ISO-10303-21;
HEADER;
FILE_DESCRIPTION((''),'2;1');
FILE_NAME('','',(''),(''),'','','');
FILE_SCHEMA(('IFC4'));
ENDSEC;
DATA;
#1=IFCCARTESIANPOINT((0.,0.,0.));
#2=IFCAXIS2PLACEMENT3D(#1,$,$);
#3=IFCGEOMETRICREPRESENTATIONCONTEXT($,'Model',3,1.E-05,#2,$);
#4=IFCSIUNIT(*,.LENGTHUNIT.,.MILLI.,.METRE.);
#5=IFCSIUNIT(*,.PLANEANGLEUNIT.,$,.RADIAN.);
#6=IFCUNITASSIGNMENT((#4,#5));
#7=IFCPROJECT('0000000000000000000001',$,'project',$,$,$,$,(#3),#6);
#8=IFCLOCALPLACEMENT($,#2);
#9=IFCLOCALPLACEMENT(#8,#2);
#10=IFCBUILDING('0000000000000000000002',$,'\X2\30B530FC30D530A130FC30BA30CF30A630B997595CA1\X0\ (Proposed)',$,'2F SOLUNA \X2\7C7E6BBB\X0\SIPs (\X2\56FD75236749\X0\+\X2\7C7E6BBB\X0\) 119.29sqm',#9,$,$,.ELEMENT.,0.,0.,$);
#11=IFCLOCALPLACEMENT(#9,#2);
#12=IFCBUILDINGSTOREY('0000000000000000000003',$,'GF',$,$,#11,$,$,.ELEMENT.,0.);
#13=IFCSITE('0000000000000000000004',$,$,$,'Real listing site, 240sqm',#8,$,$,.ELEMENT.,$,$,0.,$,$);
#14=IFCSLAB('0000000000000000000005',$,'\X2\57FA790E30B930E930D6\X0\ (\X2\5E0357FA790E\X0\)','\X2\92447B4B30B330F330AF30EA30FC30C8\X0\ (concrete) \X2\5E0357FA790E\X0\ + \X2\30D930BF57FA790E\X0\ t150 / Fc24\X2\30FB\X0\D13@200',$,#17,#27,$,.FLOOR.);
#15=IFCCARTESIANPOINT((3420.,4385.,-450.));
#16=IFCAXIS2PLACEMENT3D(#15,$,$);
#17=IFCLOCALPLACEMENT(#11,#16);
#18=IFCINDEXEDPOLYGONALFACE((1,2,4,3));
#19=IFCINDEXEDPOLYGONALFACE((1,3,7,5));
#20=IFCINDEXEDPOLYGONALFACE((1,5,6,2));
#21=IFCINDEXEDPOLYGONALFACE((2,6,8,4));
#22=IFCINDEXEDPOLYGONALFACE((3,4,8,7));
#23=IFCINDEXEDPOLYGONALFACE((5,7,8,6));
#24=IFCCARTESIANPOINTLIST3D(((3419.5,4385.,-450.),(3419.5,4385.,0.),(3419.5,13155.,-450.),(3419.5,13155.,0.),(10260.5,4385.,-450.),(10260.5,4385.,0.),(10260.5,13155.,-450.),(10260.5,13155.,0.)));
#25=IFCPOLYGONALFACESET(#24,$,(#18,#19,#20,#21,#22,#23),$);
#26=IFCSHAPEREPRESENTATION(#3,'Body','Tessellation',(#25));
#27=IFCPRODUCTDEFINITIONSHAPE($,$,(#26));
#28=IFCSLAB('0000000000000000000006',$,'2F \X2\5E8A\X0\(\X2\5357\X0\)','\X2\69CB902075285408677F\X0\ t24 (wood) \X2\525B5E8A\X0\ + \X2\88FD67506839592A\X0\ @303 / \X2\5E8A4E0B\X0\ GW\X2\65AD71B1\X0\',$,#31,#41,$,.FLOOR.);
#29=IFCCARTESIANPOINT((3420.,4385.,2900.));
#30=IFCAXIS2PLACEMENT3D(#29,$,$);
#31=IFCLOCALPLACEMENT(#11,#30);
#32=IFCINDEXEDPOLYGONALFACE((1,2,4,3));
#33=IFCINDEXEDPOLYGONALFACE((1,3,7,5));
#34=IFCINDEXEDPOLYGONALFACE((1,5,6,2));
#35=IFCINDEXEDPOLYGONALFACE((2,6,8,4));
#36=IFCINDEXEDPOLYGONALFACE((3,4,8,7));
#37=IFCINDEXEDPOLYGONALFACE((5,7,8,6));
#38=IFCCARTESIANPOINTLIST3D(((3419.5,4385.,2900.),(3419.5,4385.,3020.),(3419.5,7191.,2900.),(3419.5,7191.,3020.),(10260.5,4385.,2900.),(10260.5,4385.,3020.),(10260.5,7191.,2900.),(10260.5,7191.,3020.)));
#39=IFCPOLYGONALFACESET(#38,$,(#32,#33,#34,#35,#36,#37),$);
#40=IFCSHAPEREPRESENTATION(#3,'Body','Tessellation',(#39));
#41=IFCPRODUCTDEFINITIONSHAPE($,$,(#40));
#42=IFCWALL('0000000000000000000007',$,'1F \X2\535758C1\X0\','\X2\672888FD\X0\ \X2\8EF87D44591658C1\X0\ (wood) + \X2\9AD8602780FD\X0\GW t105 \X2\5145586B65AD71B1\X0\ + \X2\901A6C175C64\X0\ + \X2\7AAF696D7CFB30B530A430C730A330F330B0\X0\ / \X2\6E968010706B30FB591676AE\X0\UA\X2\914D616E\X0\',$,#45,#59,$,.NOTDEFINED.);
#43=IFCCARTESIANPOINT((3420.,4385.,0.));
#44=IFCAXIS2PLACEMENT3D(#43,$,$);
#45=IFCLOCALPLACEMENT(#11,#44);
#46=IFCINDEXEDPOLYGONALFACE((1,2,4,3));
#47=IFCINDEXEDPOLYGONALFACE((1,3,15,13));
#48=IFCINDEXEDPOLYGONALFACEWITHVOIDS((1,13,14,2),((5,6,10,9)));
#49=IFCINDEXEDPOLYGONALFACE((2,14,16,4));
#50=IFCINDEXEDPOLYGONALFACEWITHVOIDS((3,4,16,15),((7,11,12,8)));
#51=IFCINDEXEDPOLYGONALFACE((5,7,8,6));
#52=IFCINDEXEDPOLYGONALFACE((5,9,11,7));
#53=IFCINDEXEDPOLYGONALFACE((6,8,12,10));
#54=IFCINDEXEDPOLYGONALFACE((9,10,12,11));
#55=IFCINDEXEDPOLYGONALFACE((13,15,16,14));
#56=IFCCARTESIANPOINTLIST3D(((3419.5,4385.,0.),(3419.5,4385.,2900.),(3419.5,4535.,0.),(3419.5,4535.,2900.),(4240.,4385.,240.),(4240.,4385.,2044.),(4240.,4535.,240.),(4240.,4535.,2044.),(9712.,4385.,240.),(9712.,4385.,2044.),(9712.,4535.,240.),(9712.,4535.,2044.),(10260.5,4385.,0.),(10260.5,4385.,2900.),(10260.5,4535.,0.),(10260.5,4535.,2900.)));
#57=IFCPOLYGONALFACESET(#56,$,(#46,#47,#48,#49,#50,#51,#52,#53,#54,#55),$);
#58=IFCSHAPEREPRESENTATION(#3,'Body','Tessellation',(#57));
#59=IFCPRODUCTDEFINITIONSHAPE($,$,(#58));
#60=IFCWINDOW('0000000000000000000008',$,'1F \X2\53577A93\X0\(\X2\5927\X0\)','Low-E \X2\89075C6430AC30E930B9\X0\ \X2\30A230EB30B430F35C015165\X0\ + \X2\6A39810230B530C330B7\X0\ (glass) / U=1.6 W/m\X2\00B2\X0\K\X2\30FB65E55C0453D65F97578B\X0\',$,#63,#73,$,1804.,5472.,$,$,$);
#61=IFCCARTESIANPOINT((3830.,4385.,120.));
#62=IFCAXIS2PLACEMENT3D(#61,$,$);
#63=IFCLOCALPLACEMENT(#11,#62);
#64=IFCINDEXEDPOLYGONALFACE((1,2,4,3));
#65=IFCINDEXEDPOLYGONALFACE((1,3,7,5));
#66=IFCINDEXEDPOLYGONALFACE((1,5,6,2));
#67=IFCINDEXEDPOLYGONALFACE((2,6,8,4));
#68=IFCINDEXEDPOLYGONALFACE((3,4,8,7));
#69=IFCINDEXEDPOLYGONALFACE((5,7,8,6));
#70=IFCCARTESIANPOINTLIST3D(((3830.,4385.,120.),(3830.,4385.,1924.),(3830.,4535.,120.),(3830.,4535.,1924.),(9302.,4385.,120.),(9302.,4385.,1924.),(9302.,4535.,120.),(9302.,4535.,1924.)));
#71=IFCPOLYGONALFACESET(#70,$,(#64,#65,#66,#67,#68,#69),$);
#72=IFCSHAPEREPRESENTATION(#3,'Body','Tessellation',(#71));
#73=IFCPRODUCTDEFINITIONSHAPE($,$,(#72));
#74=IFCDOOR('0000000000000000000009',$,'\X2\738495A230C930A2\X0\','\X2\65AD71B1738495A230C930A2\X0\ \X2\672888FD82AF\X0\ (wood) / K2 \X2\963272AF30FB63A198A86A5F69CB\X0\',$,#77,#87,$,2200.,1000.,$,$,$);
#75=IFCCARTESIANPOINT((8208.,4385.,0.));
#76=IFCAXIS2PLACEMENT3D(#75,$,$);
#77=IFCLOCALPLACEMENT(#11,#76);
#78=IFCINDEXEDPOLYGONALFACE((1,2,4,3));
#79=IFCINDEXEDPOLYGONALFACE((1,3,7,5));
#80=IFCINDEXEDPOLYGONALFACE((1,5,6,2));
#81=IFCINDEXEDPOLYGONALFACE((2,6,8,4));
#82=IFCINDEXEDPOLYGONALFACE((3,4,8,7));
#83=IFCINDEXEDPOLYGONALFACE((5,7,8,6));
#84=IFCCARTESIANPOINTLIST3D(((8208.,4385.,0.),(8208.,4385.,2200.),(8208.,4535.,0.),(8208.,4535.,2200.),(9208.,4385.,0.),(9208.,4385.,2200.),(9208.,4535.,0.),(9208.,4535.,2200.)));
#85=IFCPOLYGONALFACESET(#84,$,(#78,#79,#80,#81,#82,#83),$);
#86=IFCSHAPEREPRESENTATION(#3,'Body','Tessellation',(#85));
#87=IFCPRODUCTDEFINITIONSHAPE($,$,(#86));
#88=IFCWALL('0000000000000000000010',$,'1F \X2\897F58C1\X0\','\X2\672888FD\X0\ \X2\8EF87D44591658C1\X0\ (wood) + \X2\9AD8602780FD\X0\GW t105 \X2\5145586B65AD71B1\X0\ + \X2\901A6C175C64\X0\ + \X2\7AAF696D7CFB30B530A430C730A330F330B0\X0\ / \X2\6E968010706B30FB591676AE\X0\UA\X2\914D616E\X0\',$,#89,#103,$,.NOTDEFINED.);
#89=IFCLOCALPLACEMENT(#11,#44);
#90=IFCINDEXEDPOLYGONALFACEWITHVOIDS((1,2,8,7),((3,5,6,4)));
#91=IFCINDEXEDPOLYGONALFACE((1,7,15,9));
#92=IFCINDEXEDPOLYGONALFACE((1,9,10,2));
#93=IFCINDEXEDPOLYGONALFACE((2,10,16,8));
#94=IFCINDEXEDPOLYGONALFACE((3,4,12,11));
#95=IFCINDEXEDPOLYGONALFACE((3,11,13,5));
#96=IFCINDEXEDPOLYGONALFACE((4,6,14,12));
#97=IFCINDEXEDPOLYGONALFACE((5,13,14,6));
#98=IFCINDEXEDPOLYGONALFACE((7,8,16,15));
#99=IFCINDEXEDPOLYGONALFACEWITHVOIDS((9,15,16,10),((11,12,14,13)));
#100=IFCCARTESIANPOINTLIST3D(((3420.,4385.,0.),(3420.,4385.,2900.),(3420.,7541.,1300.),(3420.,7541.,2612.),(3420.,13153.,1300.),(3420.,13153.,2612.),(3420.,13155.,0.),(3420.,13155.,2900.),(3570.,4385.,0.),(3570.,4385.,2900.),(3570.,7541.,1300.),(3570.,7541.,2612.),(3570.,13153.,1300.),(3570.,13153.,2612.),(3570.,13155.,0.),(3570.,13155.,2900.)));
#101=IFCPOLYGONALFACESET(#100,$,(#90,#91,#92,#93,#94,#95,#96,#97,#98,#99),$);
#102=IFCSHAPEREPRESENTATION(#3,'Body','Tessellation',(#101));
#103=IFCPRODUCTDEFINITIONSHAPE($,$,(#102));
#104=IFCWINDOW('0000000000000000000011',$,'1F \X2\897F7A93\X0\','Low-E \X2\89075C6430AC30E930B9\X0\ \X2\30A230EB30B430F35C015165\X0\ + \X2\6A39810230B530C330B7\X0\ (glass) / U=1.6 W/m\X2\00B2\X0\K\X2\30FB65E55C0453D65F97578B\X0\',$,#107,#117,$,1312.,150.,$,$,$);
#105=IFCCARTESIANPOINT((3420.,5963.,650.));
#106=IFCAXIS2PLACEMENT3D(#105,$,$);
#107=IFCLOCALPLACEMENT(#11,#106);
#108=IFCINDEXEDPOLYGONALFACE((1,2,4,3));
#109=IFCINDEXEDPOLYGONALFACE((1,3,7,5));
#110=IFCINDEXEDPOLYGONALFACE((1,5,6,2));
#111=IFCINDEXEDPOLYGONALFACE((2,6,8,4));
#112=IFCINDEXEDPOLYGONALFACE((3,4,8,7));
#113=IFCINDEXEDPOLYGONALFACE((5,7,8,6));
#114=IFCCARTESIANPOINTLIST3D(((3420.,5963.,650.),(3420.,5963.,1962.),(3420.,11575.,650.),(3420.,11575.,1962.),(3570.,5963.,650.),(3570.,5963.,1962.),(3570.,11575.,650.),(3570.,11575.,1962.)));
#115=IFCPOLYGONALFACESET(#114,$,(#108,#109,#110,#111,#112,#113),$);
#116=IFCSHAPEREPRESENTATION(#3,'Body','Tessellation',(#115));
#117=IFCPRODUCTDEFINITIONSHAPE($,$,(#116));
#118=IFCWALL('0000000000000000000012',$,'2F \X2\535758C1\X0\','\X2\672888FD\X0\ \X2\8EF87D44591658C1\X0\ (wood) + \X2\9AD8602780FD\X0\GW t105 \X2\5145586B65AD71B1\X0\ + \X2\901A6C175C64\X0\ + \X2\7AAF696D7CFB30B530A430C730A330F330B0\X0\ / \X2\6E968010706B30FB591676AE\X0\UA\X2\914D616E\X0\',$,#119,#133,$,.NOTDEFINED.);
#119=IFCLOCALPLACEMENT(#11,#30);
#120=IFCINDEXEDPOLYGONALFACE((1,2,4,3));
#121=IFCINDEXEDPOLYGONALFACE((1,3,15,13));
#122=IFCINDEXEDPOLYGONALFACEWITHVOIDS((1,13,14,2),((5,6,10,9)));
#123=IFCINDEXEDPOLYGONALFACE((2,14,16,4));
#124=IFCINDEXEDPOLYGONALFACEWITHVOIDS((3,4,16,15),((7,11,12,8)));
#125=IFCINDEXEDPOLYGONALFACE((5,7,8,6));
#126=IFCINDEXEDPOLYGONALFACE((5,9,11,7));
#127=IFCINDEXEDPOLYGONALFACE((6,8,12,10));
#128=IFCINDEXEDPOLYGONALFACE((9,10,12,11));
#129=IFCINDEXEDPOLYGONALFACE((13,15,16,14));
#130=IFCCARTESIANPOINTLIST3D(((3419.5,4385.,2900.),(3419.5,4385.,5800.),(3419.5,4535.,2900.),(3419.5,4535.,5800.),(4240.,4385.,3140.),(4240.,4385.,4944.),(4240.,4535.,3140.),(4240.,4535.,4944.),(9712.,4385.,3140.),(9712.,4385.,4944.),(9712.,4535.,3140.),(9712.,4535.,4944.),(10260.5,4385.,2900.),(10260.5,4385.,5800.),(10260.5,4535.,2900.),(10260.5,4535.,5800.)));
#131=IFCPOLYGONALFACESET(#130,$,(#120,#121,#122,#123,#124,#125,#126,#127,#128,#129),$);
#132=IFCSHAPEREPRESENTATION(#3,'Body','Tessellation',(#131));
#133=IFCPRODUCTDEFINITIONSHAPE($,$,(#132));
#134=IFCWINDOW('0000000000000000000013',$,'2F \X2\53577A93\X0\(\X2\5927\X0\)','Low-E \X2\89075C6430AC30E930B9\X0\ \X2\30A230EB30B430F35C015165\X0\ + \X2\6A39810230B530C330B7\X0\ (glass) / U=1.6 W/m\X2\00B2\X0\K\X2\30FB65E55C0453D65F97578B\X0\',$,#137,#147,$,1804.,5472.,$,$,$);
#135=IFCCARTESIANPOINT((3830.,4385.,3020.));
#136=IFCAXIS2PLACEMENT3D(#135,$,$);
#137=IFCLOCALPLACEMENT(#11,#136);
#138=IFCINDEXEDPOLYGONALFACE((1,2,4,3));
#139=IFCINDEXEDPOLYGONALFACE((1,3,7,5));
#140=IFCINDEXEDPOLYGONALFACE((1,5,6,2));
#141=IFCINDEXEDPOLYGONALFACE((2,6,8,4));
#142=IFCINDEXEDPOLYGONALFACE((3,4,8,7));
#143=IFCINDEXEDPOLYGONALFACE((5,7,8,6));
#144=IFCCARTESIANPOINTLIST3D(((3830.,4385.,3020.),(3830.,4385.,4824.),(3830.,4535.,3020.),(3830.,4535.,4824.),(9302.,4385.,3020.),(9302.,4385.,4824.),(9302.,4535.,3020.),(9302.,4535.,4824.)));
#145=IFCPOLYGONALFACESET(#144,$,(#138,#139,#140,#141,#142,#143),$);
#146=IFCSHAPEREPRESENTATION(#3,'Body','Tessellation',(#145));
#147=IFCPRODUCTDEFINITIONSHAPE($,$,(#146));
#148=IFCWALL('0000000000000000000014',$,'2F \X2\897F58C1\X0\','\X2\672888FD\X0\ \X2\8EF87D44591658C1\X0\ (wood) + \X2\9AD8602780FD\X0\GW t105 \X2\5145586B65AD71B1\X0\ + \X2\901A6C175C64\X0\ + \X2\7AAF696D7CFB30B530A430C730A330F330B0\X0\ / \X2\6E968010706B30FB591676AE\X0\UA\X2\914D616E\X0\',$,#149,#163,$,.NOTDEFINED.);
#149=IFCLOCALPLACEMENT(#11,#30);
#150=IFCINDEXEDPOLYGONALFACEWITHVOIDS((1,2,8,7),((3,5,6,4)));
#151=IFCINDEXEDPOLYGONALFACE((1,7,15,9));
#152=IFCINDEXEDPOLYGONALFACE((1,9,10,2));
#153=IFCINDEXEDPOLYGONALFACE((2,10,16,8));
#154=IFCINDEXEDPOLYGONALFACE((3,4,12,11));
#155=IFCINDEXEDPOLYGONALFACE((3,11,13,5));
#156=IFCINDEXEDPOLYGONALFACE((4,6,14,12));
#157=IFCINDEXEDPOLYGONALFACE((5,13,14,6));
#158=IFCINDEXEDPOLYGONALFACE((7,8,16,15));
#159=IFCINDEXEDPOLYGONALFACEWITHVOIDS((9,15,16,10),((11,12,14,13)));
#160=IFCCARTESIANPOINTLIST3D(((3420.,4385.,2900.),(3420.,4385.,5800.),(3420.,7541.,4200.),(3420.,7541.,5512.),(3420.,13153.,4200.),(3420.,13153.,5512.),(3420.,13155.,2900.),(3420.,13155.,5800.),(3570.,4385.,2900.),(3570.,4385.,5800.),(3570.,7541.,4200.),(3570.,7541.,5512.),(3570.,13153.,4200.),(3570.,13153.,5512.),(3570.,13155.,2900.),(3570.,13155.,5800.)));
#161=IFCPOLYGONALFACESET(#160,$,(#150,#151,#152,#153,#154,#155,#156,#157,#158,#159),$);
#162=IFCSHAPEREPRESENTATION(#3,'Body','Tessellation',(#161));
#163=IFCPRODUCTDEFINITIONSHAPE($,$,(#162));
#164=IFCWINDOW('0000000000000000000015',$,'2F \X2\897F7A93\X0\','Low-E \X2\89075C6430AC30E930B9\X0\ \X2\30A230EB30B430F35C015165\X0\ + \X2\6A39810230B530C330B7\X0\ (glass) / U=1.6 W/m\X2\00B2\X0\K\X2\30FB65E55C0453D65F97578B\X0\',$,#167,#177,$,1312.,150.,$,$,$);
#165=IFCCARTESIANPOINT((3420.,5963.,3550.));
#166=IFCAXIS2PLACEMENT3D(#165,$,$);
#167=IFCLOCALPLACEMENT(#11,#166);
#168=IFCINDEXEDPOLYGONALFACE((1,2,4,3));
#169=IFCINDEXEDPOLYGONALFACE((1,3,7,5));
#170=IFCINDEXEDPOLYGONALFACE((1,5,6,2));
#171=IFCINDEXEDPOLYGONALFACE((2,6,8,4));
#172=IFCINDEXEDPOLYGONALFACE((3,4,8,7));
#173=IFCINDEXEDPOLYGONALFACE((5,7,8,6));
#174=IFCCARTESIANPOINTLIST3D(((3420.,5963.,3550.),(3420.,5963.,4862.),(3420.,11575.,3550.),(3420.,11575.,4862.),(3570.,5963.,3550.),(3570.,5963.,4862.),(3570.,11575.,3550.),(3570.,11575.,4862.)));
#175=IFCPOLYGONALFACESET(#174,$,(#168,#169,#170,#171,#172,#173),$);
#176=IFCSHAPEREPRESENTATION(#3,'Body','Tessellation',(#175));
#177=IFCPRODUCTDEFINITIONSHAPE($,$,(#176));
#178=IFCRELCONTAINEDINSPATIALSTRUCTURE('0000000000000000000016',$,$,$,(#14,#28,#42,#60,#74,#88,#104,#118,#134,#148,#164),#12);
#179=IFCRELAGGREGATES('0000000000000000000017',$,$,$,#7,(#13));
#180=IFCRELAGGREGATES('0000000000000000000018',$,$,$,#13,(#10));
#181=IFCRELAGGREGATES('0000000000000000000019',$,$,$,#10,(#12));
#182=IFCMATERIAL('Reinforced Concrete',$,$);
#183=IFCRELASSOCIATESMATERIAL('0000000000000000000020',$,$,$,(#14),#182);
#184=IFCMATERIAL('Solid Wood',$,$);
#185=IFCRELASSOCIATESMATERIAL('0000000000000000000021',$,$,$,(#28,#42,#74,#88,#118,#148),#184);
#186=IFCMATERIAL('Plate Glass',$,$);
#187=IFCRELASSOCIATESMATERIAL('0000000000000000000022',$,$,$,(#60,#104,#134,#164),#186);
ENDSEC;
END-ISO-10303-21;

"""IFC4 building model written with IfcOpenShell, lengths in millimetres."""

from ifc_helpers import new_model, si_unit, frame, frame_2d, origin, place, context, project, spatial, rectangle, extrude, material, element, fill, save


model = new_model("IFC4")

# Units and contexts
model_context = context("Model", 3, precision=1e-05, world=origin())
ifc_project = project(units=[si_unit("LENGTHUNIT", "METRE", prefix="MILLI"), si_unit("PLANEANGLEUNIT", "RADIAN")], contexts=[model_context])

# Site, building, storey
site_placement = place(None, origin())
site = spatial("IfcSite", under=ifc_project, at=site_placement, ObjectType="Real listing site, 240sqm", CompositionType="ELEMENT", RefElevation=0.0)
building_placement = place(site_placement, origin())
building = spatial("IfcBuilding", under=site, at=building_placement, Name="サーファーズハウス静岡 (Proposed)", ObjectType="2F SOLUNA 籾殻SIPs (国産杉+籾殻) 119.29sqm", CompositionType="ELEMENT", ElevationOfRefHeight=0.0, ElevationOfTerrain=0.0)
storey_placement = place(building_placement, origin())
storey = spatial("IfcBuildingStorey", under=building, at=storey_placement, Name="GF", CompositionType="ELEMENT", Elevation=0.0)

# Slabs
ifc_material_1 = material(Name="Reinforced Concrete")
slab_1_placement = place(storey_placement, frame((3420.0, 4385.0, -450.0)))
element("IfcSlab", 1, at=slab_1_placement, inside=storey, material=ifc_material_1, Name="基礎スラブ (布基礎)", Description="鉄筋コンクリート (concrete) 布基礎 + ベタ基礎 t150 / Fc24・D13@200", PredefinedType="FLOOR", context=model_context, shape_type="SweptSolid", body=[
    extrude(rectangle(XDim=6841.0, YDim=8770.0, at=frame_2d((3420.0, 4385.0))), frame((3420.0, 4385.0, -450.0)), (0.0, 0.0, 1.0), 450.0),
])
ifc_material_2 = material(Name="Solid Wood")
slab_2_placement = place(storey_placement, frame((3420.0, 4385.0, 2900.0)))
element("IfcSlab", 2, at=slab_2_placement, inside=storey, material=ifc_material_2, Name="2F 床(南)", Description="構造用合板 t24 (wood) 剛床 + 製材根太 @303 / 床下 GW断熱", PredefinedType="FLOOR", context=model_context, shape_type="SweptSolid", body=[
    extrude(rectangle(XDim=6841.0, YDim=2806.0, at=frame_2d((3420.0, 1403.0))), frame((3420.0, 4385.0, 2900.0)), (0.0, 0.0, 1.0), 120.0),
])

# Wall, openings, window, door
wall_1_placement = place(storey_placement, frame((3420.0, 4385.0, 0.0)))
wall_1 = element("IfcWall", 3, at=wall_1_placement, inside=storey, material=ifc_material_2, Name="1F 南壁", Description="木製 軸組外壁 (wood) + 高性能GW t105 充填断熱 + 通気層 + 窯業系サイディング / 準耐火・外皮UA配慮", PredefinedType="NOTDEFINED", context=model_context, shape_type="SweptSolid", body=[
    extrude(rectangle(XDim=6841.0, YDim=150.0, at=frame_2d((3420.0, 75.0))), frame((3420.0, 4385.0, 0.0)), (0.0, 0.0, 1.0), 2900.0),
])
opening_1_placement = place(storey_placement, frame((3830.0, 4385.0, 120.0)))
opening_1 = element("IfcOpeningElement", 4, at=opening_1_placement, cuts=wall_1, PredefinedType="NOTDEFINED", context=model_context, shape_type="SweptSolid", body=[
    extrude(rectangle(XDim=5472.0, YDim=150.0, at=frame_2d((2736.0, 75.0))), frame((3830.0, 4385.0, 120.0)), (0.0, 0.0, 1.0), 1804.0),
])
opening_2_placement = place(storey_placement, frame((8208.0, 4385.0, 0.0)))
opening_2 = element("IfcOpeningElement", 5, at=opening_2_placement, cuts=wall_1, PredefinedType="NOTDEFINED", context=model_context, shape_type="SweptSolid", body=[
    extrude(rectangle(XDim=1000.0, YDim=150.0, at=frame_2d((500.0, 75.0))), frame((8208.0, 4385.0, 0.0)), (0.0, 0.0, 1.0), 2200.0),
])
ifc_material_3 = material(Name="Plate Glass")
window_1_placement = place(storey_placement, frame((3830.0, 4385.0, 120.0)))
window_1 = element("IfcWindow", 6, at=window_1_placement, inside=storey, material=ifc_material_3, Name="1F 南窓(大)", Description="Low-E 複層ガラス アルゴン封入 + 樹脂サッシ (glass) / U=1.6 W/m²K・日射取得型", OverallHeight=1804.0, OverallWidth=5472.0, context=model_context, shape_type="SweptSolid", body=[
    extrude(rectangle(XDim=5472.0, YDim=150.0, at=frame_2d((2736.0, 75.0))), frame((3830.0, 4385.0, 120.0)), (0.0, 0.0, 1.0), 1804.0),
])
fill(opening_1, window_1)
door_placement = place(storey_placement, frame((8208.0, 4385.0, 0.0)))
door = element("IfcDoor", 7, at=door_placement, inside=storey, material=ifc_material_2, Name="玄関ドア", Description="断熱玄関ドア 木製芯 (wood) / K2 防犯・採風機構", OverallHeight=2200.0, OverallWidth=1000.0, context=model_context, shape_type="SweptSolid", body=[
    extrude(rectangle(XDim=1000.0, YDim=150.0, at=frame_2d((500.0, 75.0))), frame((8208.0, 4385.0, 0.0)), (0.0, 0.0, 1.0), 2200.0),
])
fill(opening_2, door)

# Walls, openings, windows
wall_2_placement = place(storey_placement, frame((3420.0, 4385.0, 0.0)))
wall_2 = element("IfcWall", 8, at=wall_2_placement, inside=storey, material=ifc_material_2, Name="1F 西壁", Description="木製 軸組外壁 (wood) + 高性能GW t105 充填断熱 + 通気層 + 窯業系サイディング / 準耐火・外皮UA配慮", PredefinedType="NOTDEFINED", context=model_context, shape_type="SweptSolid", body=[
    extrude(rectangle(XDim=150.0, YDim=8770.0, at=frame_2d((75.0, 4385.0))), frame((3420.0, 4385.0, 0.0)), (0.0, 0.0, 1.0), 2900.0),
])
opening_3_placement = place(storey_placement, frame((3420.0, 5963.0, 650.0)))
opening_3 = element("IfcOpeningElement", 9, at=opening_3_placement, cuts=wall_2, PredefinedType="NOTDEFINED", context=model_context, shape_type="SweptSolid", body=[
    extrude(rectangle(XDim=150.0, YDim=5612.0, at=frame_2d((75.0, 2806.0))), frame((3420.0, 5963.0, 650.0)), (0.0, 0.0, 1.0), 1312.0),
])
window_2_placement = place(storey_placement, frame((3420.0, 5963.0, 650.0)))
window_2 = element("IfcWindow", 10, at=window_2_placement, inside=storey, material=ifc_material_3, Name="1F 西窓", Description="Low-E 複層ガラス アルゴン封入 + 樹脂サッシ (glass) / U=1.6 W/m²K・日射取得型", OverallHeight=1312.0, OverallWidth=150.0, context=model_context, shape_type="SweptSolid", body=[
    extrude(rectangle(XDim=150.0, YDim=5612.0, at=frame_2d((75.0, 2806.0))), frame((3420.0, 5963.0, 650.0)), (0.0, 0.0, 1.0), 1312.0),
])
fill(opening_3, window_2)
wall_3_placement = place(storey_placement, frame((3420.0, 4385.0, 2900.0)))
wall_3 = element("IfcWall", 11, at=wall_3_placement, inside=storey, material=ifc_material_2, Name="2F 南壁", Description="木製 軸組外壁 (wood) + 高性能GW t105 充填断熱 + 通気層 + 窯業系サイディング / 準耐火・外皮UA配慮", PredefinedType="NOTDEFINED", context=model_context, shape_type="SweptSolid", body=[
    extrude(rectangle(XDim=6841.0, YDim=150.0, at=frame_2d((3420.0, 75.0))), frame((3420.0, 4385.0, 2900.0)), (0.0, 0.0, 1.0), 2900.0),
])
opening_4_placement = place(storey_placement, frame((3830.0, 4385.0, 3020.0)))
opening_4 = element("IfcOpeningElement", 12, at=opening_4_placement, cuts=wall_3, PredefinedType="NOTDEFINED", context=model_context, shape_type="SweptSolid", body=[
    extrude(rectangle(XDim=5472.0, YDim=150.0, at=frame_2d((2736.0, 75.0))), frame((3830.0, 4385.0, 3020.0)), (0.0, 0.0, 1.0), 1804.0),
])
window_3_placement = place(storey_placement, frame((3830.0, 4385.0, 3020.0)))
window_3 = element("IfcWindow", 13, at=window_3_placement, inside=storey, material=ifc_material_3, Name="2F 南窓(大)", Description="Low-E 複層ガラス アルゴン封入 + 樹脂サッシ (glass) / U=1.6 W/m²K・日射取得型", OverallHeight=1804.0, OverallWidth=5472.0, context=model_context, shape_type="SweptSolid", body=[
    extrude(rectangle(XDim=5472.0, YDim=150.0, at=frame_2d((2736.0, 75.0))), frame((3830.0, 4385.0, 3020.0)), (0.0, 0.0, 1.0), 1804.0),
])
fill(opening_4, window_3)
wall_4_placement = place(storey_placement, frame((3420.0, 4385.0, 2900.0)))
wall_4 = element("IfcWall", 14, at=wall_4_placement, inside=storey, material=ifc_material_2, Name="2F 西壁", Description="木製 軸組外壁 (wood) + 高性能GW t105 充填断熱 + 通気層 + 窯業系サイディング / 準耐火・外皮UA配慮", PredefinedType="NOTDEFINED", context=model_context, shape_type="SweptSolid", body=[
    extrude(rectangle(XDim=150.0, YDim=8770.0, at=frame_2d((75.0, 4385.0))), frame((3420.0, 4385.0, 2900.0)), (0.0, 0.0, 1.0), 2900.0),
])
opening_5_placement = place(storey_placement, frame((3420.0, 5963.0, 3550.0)))
opening_5 = element("IfcOpeningElement", 15, at=opening_5_placement, cuts=wall_4, PredefinedType="NOTDEFINED", context=model_context, shape_type="SweptSolid", body=[
    extrude(rectangle(XDim=150.0, YDim=5612.0, at=frame_2d((75.0, 2806.0))), frame((3420.0, 5963.0, 3550.0)), (0.0, 0.0, 1.0), 1312.0),
])
window_4_placement = place(storey_placement, frame((3420.0, 5963.0, 3550.0)))
window_4 = element("IfcWindow", 16, at=window_4_placement, inside=storey, material=ifc_material_3, Name="2F 西窓", Description="Low-E 複層ガラス アルゴン封入 + 樹脂サッシ (glass) / U=1.6 W/m²K・日射取得型", OverallHeight=1312.0, OverallWidth=150.0, context=model_context, shape_type="SweptSolid", body=[
    extrude(rectangle(XDim=150.0, YDim=5612.0, at=frame_2d((75.0, 2806.0))), frame((3420.0, 5963.0, 3550.0)), (0.0, 0.0, 1.0), 1312.0),
])
fill(opening_5, window_4)

save(model, "model.ifc")
